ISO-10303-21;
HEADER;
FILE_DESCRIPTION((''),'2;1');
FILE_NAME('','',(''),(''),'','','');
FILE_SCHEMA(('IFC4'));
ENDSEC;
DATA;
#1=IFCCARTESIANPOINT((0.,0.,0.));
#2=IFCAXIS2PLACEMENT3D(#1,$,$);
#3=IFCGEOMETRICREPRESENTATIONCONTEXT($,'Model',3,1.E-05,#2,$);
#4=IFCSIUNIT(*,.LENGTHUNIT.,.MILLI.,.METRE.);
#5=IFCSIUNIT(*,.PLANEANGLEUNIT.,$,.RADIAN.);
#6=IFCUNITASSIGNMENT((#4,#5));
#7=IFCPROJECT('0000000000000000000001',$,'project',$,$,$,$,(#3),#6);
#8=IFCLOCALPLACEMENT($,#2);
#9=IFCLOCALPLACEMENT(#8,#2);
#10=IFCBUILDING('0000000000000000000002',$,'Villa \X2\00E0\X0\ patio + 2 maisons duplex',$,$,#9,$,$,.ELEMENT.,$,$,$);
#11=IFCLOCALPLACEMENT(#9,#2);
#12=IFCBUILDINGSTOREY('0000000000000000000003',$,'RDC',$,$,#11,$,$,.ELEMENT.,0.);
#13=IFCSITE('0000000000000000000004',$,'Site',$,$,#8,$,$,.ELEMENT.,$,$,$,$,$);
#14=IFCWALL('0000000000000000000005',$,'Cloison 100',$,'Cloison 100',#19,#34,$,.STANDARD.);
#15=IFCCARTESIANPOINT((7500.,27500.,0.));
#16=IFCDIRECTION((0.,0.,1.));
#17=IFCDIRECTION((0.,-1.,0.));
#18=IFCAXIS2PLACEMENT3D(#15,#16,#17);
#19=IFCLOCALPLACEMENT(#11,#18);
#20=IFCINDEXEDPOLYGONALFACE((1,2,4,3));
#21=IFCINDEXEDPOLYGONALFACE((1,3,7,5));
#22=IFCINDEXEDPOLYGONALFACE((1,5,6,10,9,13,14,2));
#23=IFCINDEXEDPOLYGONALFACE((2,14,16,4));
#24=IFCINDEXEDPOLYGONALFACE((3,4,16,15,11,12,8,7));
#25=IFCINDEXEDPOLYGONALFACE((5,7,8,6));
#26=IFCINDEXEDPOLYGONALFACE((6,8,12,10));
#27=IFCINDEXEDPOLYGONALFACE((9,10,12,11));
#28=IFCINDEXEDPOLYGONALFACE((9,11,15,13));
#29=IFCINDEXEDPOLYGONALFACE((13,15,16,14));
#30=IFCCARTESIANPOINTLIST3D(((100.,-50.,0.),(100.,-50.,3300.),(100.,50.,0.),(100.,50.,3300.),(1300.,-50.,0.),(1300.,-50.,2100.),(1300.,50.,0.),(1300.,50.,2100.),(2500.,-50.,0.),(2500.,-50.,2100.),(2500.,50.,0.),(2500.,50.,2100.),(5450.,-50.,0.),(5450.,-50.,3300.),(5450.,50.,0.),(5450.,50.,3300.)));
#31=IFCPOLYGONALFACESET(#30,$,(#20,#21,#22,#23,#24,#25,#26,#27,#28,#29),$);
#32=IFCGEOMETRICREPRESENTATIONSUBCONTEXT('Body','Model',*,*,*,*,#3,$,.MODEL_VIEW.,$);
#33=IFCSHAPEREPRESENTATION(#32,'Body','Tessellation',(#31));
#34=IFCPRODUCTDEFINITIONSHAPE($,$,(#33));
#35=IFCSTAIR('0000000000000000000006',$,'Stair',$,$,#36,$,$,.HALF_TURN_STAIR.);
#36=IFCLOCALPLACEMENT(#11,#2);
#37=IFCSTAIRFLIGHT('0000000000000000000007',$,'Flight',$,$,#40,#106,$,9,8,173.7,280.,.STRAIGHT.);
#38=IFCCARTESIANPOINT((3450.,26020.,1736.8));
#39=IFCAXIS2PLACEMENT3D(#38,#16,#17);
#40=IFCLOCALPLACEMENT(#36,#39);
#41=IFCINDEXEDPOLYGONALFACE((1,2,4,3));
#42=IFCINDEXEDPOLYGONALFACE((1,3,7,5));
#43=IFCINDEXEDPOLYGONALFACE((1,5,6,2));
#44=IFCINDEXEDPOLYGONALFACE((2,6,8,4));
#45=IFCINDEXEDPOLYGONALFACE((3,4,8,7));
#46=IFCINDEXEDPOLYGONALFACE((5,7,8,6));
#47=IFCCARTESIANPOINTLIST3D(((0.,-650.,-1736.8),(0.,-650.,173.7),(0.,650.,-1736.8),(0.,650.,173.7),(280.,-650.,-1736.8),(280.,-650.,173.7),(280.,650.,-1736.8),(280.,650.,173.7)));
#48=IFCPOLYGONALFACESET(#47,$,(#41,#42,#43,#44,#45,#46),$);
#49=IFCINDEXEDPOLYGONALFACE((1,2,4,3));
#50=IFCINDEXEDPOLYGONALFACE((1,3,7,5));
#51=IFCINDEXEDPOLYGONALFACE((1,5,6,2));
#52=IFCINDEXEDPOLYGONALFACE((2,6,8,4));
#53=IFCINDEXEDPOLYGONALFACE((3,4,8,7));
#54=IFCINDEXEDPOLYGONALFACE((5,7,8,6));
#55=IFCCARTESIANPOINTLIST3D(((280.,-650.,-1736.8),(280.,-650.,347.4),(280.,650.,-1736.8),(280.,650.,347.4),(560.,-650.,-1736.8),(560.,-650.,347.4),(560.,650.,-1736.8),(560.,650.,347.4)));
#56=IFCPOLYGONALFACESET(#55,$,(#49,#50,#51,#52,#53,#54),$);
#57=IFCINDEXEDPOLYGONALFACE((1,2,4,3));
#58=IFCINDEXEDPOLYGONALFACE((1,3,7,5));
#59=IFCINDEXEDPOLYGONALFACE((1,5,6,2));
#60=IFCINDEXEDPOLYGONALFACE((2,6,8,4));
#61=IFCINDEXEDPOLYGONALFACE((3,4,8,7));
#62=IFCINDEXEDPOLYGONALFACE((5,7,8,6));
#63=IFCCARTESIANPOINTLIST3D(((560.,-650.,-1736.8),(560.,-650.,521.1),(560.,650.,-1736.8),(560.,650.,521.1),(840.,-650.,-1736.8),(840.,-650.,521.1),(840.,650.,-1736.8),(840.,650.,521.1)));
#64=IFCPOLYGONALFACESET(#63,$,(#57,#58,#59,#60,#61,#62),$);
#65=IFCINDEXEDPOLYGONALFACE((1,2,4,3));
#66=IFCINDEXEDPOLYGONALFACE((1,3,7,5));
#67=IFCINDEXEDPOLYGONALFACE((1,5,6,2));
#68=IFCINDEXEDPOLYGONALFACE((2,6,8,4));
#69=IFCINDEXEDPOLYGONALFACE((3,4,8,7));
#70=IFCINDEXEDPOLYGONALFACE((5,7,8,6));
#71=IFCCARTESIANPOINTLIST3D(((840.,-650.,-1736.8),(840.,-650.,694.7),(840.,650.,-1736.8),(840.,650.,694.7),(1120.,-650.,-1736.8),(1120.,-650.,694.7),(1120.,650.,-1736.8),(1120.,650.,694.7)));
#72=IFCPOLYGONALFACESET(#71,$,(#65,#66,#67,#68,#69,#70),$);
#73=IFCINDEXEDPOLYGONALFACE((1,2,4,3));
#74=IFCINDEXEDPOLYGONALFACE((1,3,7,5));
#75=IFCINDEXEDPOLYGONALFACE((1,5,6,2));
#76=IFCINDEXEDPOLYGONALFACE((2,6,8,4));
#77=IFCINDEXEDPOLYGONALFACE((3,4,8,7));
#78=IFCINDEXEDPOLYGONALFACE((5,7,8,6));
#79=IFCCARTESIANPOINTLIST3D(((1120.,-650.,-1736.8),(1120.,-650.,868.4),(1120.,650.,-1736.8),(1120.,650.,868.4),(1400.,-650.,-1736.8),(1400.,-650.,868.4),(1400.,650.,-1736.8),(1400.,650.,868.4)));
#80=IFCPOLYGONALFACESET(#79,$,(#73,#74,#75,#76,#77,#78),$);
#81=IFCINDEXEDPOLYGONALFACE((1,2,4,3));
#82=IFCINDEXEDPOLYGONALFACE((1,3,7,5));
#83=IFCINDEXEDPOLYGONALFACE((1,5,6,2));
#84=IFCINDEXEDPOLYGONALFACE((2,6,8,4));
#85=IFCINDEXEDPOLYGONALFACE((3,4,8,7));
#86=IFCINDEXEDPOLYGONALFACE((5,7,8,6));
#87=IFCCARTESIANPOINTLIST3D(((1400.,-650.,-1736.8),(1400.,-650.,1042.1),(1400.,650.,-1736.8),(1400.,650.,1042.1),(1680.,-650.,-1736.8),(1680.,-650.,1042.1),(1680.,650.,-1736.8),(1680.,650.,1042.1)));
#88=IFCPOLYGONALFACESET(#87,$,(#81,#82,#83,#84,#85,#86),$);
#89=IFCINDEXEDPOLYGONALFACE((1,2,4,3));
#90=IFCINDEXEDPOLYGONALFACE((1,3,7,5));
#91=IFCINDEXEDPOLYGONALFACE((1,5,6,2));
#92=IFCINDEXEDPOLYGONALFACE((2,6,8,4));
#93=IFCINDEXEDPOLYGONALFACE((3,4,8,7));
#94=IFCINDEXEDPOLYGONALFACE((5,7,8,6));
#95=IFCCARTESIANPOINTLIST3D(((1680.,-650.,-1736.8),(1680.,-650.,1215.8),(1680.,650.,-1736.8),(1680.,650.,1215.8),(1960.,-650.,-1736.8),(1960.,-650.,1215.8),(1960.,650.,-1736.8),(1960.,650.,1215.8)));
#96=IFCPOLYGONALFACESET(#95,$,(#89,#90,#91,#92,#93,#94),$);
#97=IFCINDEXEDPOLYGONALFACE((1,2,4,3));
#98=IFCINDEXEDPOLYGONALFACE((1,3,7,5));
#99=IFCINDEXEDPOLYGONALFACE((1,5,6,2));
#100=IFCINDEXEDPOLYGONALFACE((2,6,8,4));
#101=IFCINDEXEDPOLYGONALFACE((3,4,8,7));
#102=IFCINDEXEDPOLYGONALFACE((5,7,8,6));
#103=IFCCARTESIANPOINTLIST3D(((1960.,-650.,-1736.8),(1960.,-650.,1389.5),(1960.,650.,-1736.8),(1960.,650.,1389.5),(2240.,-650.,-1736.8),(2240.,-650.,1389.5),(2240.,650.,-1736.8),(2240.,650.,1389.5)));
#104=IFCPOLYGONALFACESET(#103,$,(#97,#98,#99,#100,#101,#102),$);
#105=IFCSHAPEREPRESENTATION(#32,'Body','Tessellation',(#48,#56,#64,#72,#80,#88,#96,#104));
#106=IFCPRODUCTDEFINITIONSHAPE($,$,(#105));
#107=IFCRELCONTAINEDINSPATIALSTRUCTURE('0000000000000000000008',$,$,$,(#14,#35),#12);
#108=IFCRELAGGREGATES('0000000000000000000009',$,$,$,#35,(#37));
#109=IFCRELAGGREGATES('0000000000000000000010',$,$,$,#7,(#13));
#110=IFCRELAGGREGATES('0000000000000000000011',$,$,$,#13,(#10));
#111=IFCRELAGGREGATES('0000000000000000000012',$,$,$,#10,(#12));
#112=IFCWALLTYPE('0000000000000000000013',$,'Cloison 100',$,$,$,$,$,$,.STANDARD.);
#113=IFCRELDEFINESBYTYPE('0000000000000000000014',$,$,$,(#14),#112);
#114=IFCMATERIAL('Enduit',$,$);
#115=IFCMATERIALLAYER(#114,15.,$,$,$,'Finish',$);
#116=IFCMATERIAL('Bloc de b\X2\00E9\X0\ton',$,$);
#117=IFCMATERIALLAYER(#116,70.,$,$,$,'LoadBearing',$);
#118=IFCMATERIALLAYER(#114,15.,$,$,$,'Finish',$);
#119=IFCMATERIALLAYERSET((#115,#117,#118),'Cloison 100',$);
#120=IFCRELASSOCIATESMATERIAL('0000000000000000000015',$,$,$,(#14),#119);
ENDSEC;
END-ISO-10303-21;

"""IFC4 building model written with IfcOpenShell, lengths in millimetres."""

from ifc_helpers import new_model, si_unit, frame, frame_2d, origin, place, context, subcontext, project, spatial, polyline, rectangle, outline, extrude, material, layer, layer_set, layer_usage, type_object, element, aggregate, save


model = new_model("IFC4")

# Units and contexts
model_context = context("Model", 3, precision=1e-05, world=origin())
body_context = subcontext(model_context, "Body", "Model", "MODEL_VIEW")
ifc_project = project(units=[si_unit("LENGTHUNIT", "METRE", prefix="MILLI"), si_unit("PLANEANGLEUNIT", "RADIAN")], contexts=[model_context])

# Site, building, storey
site_placement = place(None, origin())
site = spatial("IfcSite", under=ifc_project, at=site_placement, Name="Site", CompositionType="ELEMENT")
building_placement = place(site_placement, origin())
building = spatial("IfcBuilding", under=site, at=building_placement, Name="Villa à patio + 2 maisons duplex", CompositionType="ELEMENT")
storey_placement = place(building_placement, origin())
storey = spatial("IfcBuildingStorey", under=building, at=storey_placement, Name="RDC", CompositionType="ELEMENT", Elevation=0.0)

# Shared definitions
ifc_material_1 = material(Name="Enduit")
ifc_layer_1 = layer(ifc_material_1, 15.0, Category="Finish")
ifc_material_2 = material(Name="Bloc de béton")
ifc_layer_2 = layer(ifc_material_2, 70.0, Category="LoadBearing")
ifc_layer_3 = layer(ifc_material_1, 15.0, Category="Finish")
ifc_layer_set_1 = layer_set([ifc_layer_1, ifc_layer_2, ifc_layer_3], Name="Cloison 100")
ifc_layer_usage_1 = layer_usage(ifc_layer_set_1, "AXIS2", "NEGATIVE", 50.0)
wall_type_1 = type_object("IfcWallType", Name="Cloison 100", PredefinedType="STANDARD")

# Wall, opening
wall_1_placement = place(storey_placement, frame((7500.0, 27500.0, 0.0), z_axis=(0.0, 0.0, 1.0), x_axis=(0.0, -1.0, 0.0)))
wall_1 = element("IfcWall", 1, at=wall_1_placement, inside=storey, type_object=wall_type_1, material=ifc_layer_usage_1, Name="Cloison 100", ObjectType="Cloison 100", PredefinedType="STANDARD", context=body_context, shape_type="SweptSolid", body=[
    extrude(outline(polyline([(100.0, -50.0), (100.0, 50.0), (5450.0, 50.0), (5450.0, -50.0), (100.0, -50.0)])), origin(), (0.0, 0.0, 1.0), 3300.0),
])
opening_1_placement = place(wall_1_placement, frame((1300.0, 0.0, 0.0), z_axis=(0.0, 0.0, 1.0), x_axis=(1.0, 0.0, 0.0)))
element("IfcOpeningElement", 2, at=opening_1_placement, cuts=wall_1, PredefinedType="OPENING", context=body_context, shape_type="SweptSolid", body=[
    extrude(rectangle(XDim=1200.0, YDim=120.0, at=frame_2d((600.0, 0.0))), origin(), (0.0, 0.0, 1.0), 2100.0),
])

# Stair, stair flight
stair_placement = place(storey_placement, origin())
stair = element("IfcStair", 3, at=stair_placement, inside=storey, Name="Stair", PredefinedType="HALF_TURN_STAIR")
stair_flight_1_placement = place(stair_placement, frame((3450.0, 26020.0, 1736.8), z_axis=(0.0, 0.0, 1.0), x_axis=(0.0, -1.0, 0.0)))
stair_flight_1 = element("IfcStairFlight", 4, at=stair_flight_1_placement, Name="Flight", NumberOfRisers=9, NumberOfTreads=8, PredefinedType="STRAIGHT", RiserHeight=173.7, TreadLength=280.0, context=body_context, shape_type="SweptSolid", body=[
    extrude(rectangle(XDim=280.0, YDim=1300.0, at=frame_2d((140.0, 0.0))), frame((0.0, 0.0, -1736.8)), (0.0, 0.0, 1.0), 1910.5),
    extrude(rectangle(XDim=280.0, YDim=1300.0, at=frame_2d((420.0, 0.0))), frame((0.0, 0.0, -1736.8)), (0.0, 0.0, 1.0), 2084.2),
    extrude(rectangle(XDim=280.0, YDim=1300.0, at=frame_2d((700.0, 0.0))), frame((0.0, 0.0, -1736.8)), (0.0, 0.0, 1.0), 2257.9),
    extrude(rectangle(XDim=280.0, YDim=1300.0, at=frame_2d((980.0, 0.0))), frame((0.0, 0.0, -1736.8)), (0.0, 0.0, 1.0), 2431.6),
    extrude(rectangle(XDim=280.0, YDim=1300.0, at=frame_2d((1260.0, 0.0))), frame((0.0, 0.0, -1736.8)), (0.0, 0.0, 1.0), 2605.3),
    extrude(rectangle(XDim=280.0, YDim=1300.0, at=frame_2d((1540.0, 0.0))), frame((0.0, 0.0, -1736.8)), (0.0, 0.0, 1.0), 2778.9),
    extrude(rectangle(XDim=280.0, YDim=1300.0, at=frame_2d((1820.0, 0.0))), frame((0.0, 0.0, -1736.8)), (0.0, 0.0, 1.0), 2952.6),
    extrude(rectangle(XDim=280.0, YDim=1300.0, at=frame_2d((2100.0, 0.0))), frame((0.0, 0.0, -1736.8)), (0.0, 0.0, 1.0), 3126.3),
])
aggregate(stair, [stair_flight_1])

save(model, "model.ifc")
